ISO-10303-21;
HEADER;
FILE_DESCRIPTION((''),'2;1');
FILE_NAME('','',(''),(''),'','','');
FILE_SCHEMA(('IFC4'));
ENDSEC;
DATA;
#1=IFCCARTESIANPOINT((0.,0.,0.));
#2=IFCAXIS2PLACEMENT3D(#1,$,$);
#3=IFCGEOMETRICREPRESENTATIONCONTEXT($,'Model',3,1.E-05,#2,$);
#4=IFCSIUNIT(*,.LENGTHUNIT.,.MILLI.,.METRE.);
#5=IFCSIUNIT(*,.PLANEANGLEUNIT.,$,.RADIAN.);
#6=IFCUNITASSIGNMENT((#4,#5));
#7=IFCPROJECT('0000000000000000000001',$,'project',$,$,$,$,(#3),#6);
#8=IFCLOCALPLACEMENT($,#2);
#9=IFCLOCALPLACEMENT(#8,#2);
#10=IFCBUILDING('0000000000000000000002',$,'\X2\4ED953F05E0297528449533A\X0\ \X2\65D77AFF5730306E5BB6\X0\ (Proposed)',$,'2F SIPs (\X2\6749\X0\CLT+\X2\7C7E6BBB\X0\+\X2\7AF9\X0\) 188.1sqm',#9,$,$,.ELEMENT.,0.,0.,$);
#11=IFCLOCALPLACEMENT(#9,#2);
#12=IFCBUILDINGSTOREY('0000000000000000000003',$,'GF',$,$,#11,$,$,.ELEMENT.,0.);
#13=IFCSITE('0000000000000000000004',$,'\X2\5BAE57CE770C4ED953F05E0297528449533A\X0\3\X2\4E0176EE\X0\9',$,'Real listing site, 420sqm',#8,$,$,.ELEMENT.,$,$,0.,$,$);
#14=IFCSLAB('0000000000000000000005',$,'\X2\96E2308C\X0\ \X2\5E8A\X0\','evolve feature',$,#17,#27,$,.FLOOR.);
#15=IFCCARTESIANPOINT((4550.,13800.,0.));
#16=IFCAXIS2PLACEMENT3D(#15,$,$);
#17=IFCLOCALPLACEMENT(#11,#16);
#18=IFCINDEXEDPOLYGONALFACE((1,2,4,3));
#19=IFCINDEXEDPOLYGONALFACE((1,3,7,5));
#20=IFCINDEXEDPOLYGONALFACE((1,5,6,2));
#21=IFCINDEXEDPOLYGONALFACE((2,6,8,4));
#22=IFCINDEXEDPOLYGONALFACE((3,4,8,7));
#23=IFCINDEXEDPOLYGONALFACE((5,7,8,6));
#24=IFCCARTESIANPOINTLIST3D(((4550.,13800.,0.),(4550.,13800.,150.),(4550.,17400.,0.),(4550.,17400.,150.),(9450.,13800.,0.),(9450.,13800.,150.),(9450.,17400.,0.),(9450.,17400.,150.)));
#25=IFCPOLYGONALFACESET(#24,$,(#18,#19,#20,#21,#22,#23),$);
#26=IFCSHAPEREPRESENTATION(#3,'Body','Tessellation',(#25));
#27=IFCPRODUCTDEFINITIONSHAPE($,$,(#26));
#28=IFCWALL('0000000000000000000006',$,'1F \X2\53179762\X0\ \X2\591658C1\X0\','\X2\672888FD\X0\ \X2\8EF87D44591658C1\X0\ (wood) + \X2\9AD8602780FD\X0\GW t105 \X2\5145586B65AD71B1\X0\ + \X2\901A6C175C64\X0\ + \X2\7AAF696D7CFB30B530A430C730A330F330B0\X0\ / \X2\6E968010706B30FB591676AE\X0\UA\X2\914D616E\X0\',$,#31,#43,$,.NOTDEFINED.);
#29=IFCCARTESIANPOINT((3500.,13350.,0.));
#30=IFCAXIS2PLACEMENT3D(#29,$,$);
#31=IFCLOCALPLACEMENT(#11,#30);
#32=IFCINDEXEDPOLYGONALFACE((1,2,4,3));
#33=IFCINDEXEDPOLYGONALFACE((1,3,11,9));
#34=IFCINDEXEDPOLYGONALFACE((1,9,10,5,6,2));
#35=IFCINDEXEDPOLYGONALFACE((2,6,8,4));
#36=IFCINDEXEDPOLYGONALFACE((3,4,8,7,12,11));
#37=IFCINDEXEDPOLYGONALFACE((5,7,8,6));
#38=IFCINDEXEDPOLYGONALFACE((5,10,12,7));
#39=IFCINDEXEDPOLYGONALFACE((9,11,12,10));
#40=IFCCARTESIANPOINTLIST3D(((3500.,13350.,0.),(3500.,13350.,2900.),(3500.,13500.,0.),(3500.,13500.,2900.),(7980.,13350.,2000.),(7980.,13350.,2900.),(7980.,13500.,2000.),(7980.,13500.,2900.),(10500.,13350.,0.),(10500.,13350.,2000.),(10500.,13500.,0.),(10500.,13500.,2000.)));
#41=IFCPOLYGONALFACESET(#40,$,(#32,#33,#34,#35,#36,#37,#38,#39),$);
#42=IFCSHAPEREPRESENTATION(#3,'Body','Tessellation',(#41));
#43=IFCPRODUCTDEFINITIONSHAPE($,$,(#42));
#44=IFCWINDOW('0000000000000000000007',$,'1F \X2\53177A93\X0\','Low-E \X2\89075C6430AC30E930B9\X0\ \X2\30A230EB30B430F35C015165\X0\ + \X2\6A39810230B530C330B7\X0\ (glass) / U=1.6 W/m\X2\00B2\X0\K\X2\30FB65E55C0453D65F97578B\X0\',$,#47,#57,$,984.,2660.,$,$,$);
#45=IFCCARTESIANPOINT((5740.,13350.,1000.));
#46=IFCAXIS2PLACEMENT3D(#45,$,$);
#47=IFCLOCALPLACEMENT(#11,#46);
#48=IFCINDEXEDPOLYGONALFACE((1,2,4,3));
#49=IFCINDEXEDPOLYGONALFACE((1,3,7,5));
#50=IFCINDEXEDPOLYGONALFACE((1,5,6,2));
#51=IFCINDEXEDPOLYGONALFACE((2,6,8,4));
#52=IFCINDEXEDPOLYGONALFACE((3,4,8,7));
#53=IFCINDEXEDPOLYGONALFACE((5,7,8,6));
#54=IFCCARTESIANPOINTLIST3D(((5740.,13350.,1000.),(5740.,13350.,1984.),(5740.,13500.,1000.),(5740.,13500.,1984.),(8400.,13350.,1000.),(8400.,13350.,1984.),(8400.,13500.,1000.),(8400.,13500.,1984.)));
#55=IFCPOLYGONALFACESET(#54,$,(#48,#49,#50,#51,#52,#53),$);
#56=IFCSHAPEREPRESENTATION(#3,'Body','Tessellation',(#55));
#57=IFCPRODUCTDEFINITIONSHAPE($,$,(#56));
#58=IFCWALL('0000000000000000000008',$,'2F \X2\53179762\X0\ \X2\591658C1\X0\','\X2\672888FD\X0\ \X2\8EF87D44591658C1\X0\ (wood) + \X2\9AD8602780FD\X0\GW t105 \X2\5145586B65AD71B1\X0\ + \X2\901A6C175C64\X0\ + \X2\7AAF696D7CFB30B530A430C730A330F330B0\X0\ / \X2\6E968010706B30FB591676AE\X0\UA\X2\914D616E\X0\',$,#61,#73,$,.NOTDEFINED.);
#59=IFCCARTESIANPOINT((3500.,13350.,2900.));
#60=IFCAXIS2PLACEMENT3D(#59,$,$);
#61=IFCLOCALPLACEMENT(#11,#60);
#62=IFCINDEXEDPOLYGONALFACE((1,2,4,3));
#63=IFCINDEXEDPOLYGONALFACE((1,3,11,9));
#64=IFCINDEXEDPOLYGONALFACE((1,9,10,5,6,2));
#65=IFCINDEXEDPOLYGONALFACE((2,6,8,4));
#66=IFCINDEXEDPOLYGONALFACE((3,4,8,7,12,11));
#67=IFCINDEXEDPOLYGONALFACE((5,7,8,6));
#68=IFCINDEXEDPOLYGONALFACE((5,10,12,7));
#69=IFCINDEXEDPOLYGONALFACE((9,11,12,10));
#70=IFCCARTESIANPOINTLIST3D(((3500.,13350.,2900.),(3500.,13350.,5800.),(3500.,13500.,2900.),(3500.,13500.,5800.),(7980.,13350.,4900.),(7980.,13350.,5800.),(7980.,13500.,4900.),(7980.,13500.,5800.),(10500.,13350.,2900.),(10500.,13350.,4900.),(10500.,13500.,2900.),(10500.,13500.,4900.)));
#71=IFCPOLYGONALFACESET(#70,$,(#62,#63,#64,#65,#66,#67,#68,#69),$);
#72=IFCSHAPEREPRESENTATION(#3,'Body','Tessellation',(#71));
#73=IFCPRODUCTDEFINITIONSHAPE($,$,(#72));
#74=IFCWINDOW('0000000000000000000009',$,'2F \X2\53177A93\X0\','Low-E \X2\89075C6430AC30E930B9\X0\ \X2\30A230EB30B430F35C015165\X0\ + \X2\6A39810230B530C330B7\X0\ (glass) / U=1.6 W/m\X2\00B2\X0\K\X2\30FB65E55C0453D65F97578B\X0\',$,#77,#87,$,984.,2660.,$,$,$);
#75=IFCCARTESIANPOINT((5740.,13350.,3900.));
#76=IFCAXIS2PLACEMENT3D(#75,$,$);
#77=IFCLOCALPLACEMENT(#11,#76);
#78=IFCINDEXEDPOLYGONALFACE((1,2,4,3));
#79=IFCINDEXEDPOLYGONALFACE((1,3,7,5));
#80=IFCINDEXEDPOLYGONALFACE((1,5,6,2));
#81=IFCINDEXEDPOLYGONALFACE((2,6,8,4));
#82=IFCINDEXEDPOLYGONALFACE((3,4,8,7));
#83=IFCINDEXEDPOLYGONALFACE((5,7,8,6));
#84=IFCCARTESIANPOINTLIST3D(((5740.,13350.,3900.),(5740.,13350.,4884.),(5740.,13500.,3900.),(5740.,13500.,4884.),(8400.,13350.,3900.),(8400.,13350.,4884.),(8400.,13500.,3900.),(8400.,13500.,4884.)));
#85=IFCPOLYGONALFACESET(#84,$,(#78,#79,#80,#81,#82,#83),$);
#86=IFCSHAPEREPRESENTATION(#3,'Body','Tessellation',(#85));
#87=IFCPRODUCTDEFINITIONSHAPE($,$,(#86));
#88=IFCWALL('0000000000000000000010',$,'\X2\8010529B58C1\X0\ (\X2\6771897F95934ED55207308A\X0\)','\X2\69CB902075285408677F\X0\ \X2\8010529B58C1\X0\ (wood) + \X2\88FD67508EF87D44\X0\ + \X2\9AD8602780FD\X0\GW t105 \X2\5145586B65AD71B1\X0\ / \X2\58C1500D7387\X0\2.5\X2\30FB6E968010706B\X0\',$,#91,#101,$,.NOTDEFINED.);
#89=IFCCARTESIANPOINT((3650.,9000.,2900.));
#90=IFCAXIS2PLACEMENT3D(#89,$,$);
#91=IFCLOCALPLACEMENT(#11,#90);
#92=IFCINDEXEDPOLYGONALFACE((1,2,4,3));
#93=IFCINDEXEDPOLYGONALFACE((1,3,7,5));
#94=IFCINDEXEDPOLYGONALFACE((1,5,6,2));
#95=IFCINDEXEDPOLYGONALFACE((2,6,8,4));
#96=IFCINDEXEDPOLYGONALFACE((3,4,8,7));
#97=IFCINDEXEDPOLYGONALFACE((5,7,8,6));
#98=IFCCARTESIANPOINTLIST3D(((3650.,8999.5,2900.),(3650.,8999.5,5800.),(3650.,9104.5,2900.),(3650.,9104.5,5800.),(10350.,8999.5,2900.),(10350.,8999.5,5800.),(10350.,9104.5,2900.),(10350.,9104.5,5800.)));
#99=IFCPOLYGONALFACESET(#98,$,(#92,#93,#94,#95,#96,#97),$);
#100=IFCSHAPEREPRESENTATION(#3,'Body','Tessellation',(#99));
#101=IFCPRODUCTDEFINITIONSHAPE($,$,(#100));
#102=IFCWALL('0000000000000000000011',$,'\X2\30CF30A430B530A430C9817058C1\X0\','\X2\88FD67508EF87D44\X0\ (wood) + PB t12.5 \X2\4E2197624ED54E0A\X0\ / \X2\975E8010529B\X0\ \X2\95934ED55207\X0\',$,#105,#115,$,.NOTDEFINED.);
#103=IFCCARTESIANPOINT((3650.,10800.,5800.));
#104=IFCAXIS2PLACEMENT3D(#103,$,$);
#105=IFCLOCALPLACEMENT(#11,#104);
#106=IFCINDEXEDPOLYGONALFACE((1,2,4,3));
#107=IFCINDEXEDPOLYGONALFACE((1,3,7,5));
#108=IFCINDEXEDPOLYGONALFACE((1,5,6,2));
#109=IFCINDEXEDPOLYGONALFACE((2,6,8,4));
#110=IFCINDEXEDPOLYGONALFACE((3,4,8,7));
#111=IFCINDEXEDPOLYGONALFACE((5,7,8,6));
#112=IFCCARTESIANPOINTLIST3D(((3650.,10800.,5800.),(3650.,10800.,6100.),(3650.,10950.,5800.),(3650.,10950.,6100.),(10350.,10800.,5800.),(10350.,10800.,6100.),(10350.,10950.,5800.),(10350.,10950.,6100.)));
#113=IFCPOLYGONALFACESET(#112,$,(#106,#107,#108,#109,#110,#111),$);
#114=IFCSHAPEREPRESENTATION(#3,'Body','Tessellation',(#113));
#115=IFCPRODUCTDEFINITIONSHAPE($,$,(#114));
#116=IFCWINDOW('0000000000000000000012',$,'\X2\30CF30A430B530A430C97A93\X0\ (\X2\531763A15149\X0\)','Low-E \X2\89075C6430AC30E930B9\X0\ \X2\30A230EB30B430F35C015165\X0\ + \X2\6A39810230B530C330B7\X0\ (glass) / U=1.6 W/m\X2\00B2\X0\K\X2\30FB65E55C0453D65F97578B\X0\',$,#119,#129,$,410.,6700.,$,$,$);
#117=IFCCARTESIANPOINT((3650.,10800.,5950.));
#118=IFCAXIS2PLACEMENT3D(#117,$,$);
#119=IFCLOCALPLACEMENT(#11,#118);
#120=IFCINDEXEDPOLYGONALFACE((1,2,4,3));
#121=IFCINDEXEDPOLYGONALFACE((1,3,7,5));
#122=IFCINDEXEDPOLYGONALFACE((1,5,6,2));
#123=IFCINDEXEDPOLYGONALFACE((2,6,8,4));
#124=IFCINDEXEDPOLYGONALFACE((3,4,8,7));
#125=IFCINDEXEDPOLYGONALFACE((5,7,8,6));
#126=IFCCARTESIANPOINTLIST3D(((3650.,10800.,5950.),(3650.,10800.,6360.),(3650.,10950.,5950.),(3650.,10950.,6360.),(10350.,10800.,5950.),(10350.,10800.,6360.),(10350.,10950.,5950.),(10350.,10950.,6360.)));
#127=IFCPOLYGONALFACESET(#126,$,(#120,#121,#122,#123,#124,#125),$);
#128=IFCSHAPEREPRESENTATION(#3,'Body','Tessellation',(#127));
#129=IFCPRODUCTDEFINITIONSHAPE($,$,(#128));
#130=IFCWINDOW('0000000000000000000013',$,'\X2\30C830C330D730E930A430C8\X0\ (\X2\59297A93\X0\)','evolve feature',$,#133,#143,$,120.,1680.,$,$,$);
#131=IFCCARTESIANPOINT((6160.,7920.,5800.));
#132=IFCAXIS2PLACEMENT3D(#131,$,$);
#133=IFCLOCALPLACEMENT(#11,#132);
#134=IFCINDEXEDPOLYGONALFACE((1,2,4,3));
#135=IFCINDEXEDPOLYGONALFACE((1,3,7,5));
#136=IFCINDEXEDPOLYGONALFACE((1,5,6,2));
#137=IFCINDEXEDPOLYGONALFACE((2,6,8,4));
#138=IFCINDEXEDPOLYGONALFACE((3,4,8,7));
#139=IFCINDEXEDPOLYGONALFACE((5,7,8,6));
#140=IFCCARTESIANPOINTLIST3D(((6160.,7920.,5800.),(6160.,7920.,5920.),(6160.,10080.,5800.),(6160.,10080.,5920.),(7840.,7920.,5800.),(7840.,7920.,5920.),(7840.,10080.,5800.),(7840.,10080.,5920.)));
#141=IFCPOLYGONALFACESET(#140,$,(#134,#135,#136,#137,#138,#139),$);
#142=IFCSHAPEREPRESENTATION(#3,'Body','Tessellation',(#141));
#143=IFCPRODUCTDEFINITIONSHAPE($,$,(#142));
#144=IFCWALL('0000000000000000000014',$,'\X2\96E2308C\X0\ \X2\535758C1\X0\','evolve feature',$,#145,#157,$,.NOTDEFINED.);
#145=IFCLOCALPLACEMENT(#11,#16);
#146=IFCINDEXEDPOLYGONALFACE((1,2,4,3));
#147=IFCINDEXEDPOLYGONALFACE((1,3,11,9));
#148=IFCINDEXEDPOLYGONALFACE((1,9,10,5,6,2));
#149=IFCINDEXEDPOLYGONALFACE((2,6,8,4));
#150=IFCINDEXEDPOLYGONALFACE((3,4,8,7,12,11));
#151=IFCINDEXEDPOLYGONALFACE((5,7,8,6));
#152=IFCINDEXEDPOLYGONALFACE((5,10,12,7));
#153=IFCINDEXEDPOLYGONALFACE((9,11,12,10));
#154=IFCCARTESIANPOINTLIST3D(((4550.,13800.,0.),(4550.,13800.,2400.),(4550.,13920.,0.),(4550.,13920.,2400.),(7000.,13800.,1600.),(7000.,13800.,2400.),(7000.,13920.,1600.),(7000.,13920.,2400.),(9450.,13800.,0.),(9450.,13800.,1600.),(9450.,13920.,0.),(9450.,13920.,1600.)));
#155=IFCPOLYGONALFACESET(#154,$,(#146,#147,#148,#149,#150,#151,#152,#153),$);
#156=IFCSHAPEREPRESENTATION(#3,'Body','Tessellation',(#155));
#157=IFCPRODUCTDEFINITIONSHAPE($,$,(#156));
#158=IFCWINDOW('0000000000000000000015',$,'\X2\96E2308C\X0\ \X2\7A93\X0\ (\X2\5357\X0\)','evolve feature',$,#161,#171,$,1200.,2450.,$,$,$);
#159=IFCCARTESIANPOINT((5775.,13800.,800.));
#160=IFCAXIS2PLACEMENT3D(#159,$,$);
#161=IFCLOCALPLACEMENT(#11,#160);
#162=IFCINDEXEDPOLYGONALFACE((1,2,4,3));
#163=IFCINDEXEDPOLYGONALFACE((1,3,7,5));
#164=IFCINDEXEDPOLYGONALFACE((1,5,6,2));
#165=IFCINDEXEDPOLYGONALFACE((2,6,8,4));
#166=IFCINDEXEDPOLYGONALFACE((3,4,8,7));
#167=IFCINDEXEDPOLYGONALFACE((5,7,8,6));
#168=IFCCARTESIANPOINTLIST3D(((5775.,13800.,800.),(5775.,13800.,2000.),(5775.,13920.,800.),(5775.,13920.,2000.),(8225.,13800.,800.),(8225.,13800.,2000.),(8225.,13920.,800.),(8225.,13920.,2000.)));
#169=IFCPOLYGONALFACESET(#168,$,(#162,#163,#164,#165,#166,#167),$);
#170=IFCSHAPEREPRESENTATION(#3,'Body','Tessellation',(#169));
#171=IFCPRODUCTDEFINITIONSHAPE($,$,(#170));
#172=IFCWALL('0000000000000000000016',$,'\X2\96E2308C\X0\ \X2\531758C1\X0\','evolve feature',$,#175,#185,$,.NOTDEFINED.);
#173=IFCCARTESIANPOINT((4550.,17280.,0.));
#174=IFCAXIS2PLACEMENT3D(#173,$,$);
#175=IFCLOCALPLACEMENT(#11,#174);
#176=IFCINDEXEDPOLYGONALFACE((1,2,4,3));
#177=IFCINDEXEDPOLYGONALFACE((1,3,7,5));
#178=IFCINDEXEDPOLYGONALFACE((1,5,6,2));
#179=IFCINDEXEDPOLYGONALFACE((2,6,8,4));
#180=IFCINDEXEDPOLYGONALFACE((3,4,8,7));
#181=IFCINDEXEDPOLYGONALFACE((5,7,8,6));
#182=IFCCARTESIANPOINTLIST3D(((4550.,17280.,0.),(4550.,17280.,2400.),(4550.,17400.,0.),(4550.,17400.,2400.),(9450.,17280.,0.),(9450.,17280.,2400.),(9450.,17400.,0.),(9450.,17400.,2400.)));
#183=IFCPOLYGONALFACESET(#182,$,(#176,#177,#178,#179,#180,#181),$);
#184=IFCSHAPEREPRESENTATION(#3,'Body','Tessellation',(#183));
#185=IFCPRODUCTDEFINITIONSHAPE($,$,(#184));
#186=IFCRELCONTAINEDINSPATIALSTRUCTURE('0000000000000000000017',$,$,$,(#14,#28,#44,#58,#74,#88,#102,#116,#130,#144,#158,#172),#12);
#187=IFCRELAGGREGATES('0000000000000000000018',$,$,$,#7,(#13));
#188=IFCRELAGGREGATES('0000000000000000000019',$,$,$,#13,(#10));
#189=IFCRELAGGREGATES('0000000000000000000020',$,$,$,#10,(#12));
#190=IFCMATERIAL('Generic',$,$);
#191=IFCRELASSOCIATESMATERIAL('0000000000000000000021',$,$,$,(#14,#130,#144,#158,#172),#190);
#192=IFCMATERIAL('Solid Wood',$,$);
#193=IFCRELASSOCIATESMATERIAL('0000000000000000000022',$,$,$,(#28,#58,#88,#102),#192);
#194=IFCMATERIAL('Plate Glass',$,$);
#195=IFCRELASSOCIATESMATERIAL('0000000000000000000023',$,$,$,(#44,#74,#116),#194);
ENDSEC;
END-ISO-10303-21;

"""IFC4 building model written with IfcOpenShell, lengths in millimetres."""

from ifc_helpers import new_model, si_unit, frame, frame_2d, origin, place, context, project, spatial, rectangle, extrude, material, element, fill, save


model = new_model("IFC4")

# Units and contexts
model_context = context("Model", 3, precision=1e-05, world=origin())
ifc_project = project(units=[si_unit("LENGTHUNIT", "METRE", prefix="MILLI"), si_unit("PLANEANGLEUNIT", "RADIAN")], contexts=[model_context])

# Site, building, storey
site_placement = place(None, origin())
site = spatial("IfcSite", under=ifc_project, at=site_placement, Name="宮城県仙台市青葉区3丁目9", ObjectType="Real listing site, 420sqm", CompositionType="ELEMENT", RefElevation=0.0)
building_placement = place(site_placement, origin())
building = spatial("IfcBuilding", under=site, at=building_placement, Name="仙台市青葉区 旗竿地の家 (Proposed)", ObjectType="2F SIPs (杉CLT+籾殻+竹) 188.1sqm", CompositionType="ELEMENT", ElevationOfRefHeight=0.0, ElevationOfTerrain=0.0)
storey_placement = place(building_placement, origin())
storey = spatial("IfcBuildingStorey", under=building, at=storey_placement, Name="GF", CompositionType="ELEMENT", Elevation=0.0)

# Slab
ifc_material_1 = material(Name="Generic")
slab_placement = place(storey_placement, frame((4550.0, 13800.0, 0.0)))
element("IfcSlab", 1, at=slab_placement, inside=storey, material=ifc_material_1, Name="離れ 床", Description="evolve feature", PredefinedType="FLOOR", context=model_context, shape_type="SweptSolid", body=[
    extrude(rectangle(XDim=4900.0, YDim=3600.0, at=frame_2d((2450.0, 1800.0))), frame((4550.0, 13800.0, 0.0)), (0.0, 0.0, 1.0), 150.0),
])

# Wall, opening, window
ifc_material_2 = material(Name="Solid Wood")
wall_1_placement = place(storey_placement, frame((3500.0, 13350.0, 0.0)))
wall_1 = element("IfcWall", 2, at=wall_1_placement, inside=storey, material=ifc_material_2, Name="1F 北面 外壁", Description="木製 軸組外壁 (wood) + 高性能GW t105 充填断熱 + 通気層 + 窯業系サイディング / 準耐火・外皮UA配慮", PredefinedType="NOTDEFINED", context=model_context, shape_type="SweptSolid", body=[
    extrude(rectangle(XDim=7000.0, YDim=150.0, at=frame_2d((3500.0, 75.0))), frame((3500.0, 13350.0, 0.0)), (0.0, 0.0, 1.0), 2900.0),
])
opening_1_placement = place(storey_placement, frame((5740.0, 13350.0, 1000.0)))
opening_1 = element("IfcOpeningElement", 3, at=opening_1_placement, cuts=wall_1, PredefinedType="NOTDEFINED", context=model_context, shape_type="SweptSolid", body=[
    extrude(rectangle(XDim=2660.0, YDim=150.0, at=frame_2d((1330.0, 75.0))), frame((5740.0, 13350.0, 1000.0)), (0.0, 0.0, 1.0), 984.0),
])
ifc_material_3 = material(Name="Plate Glass")
window_1_placement = place(storey_placement, frame((5740.0, 13350.0, 1000.0)))
window_1 = element("IfcWindow", 4, at=window_1_placement, inside=storey, material=ifc_material_3, Name="1F 北窓", Description="Low-E 複層ガラス アルゴン封入 + 樹脂サッシ (glass) / U=1.6 W/m²K・日射取得型", OverallHeight=984.0, OverallWidth=2660.0, context=model_context, shape_type="SweptSolid", body=[
    extrude(rectangle(XDim=2660.0, YDim=150.0, at=frame_2d((1330.0, 75.0))), frame((5740.0, 13350.0, 1000.0)), (0.0, 0.0, 1.0), 984.0),
])
fill(opening_1, window_1)

# Wall, opening, window
wall_2_placement = place(storey_placement, frame((3500.0, 13350.0, 2900.0)))
wall_2 = element("IfcWall", 5, at=wall_2_placement, inside=storey, material=ifc_material_2, Name="2F 北面 外壁", Description="木製 軸組外壁 (wood) + 高性能GW t105 充填断熱 + 通気層 + 窯業系サイディング / 準耐火・外皮UA配慮", PredefinedType="NOTDEFINED", context=model_context, shape_type="SweptSolid", body=[
    extrude(rectangle(XDim=7000.0, YDim=150.0, at=frame_2d((3500.0, 75.0))), frame((3500.0, 13350.0, 2900.0)), (0.0, 0.0, 1.0), 2900.0),
])
opening_2_placement = place(storey_placement, frame((5740.0, 13350.0, 3900.0)))
opening_2 = element("IfcOpeningElement", 6, at=opening_2_placement, cuts=wall_2, PredefinedType="NOTDEFINED", context=model_context, shape_type="SweptSolid", body=[
    extrude(rectangle(XDim=2660.0, YDim=150.0, at=frame_2d((1330.0, 75.0))), frame((5740.0, 13350.0, 3900.0)), (0.0, 0.0, 1.0), 984.0),
])
window_2_placement = place(storey_placement, frame((5740.0, 13350.0, 3900.0)))
window_2 = element("IfcWindow", 7, at=window_2_placement, inside=storey, material=ifc_material_3, Name="2F 北窓", Description="Low-E 複層ガラス アルゴン封入 + 樹脂サッシ (glass) / U=1.6 W/m²K・日射取得型", OverallHeight=984.0, OverallWidth=2660.0, context=model_context, shape_type="SweptSolid", body=[
    extrude(rectangle(XDim=2660.0, YDim=150.0, at=frame_2d((1330.0, 75.0))), frame((5740.0, 13350.0, 3900.0)), (0.0, 0.0, 1.0), 984.0),
])
fill(opening_2, window_2)

# Wall
wall_3_placement = place(storey_placement, frame((3650.0, 9000.0, 2900.0)))
element("IfcWall", 8, at=wall_3_placement, inside=storey, material=ifc_material_2, Name="耐力壁 (東西間仕切り)", Description="構造用合板 耐力壁 (wood) + 製材軸組 + 高性能GW t105 充填断熱 / 壁倍率2.5・準耐火", PredefinedType="NOTDEFINED", context=model_context, shape_type="SweptSolid", body=[
    extrude(rectangle(XDim=6700.0, YDim=105.0, at=frame_2d((3350.0, 52.0))), frame((3650.0, 9000.0, 2900.0)), (0.0, 0.0, 1.0), 2900.0),
])

# Wall, opening, window
wall_4_placement = place(storey_placement, frame((3650.0, 10800.0, 5800.0)))
wall_4 = element("IfcWall", 9, at=wall_4_placement, inside=storey, material=ifc_material_2, Name="ハイサイド腰壁", Description="製材軸組 (wood) + PB t12.5 両面仕上 / 非耐力 間仕切", PredefinedType="NOTDEFINED", context=model_context, shape_type="SweptSolid", body=[
    extrude(rectangle(XDim=6700.0, YDim=150.0, at=frame_2d((3350.0, 75.0))), frame((3650.0, 10800.0, 5800.0)), (0.0, 0.0, 1.0), 700.0),
])
opening_3_placement = place(storey_placement, frame((3650.0, 10800.0, 5950.0)))
opening_3 = element("IfcOpeningElement", 10, at=opening_3_placement, cuts=wall_4, PredefinedType="NOTDEFINED", context=model_context, shape_type="SweptSolid", body=[
    extrude(rectangle(XDim=6700.0, YDim=150.0, at=frame_2d((3350.0, 75.0))), frame((3650.0, 10800.0, 5950.0)), (0.0, 0.0, 1.0), 410.0),
])
window_3_placement = place(storey_placement, frame((3650.0, 10800.0, 5950.0)))
window_3 = element("IfcWindow", 11, at=window_3_placement, inside=storey, material=ifc_material_3, Name="ハイサイド窓 (北採光)", Description="Low-E 複層ガラス アルゴン封入 + 樹脂サッシ (glass) / U=1.6 W/m²K・日射取得型", OverallHeight=410.0, OverallWidth=6700.0, context=model_context, shape_type="SweptSolid", body=[
    extrude(rectangle(XDim=6700.0, YDim=150.0, at=frame_2d((3350.0, 75.0))), frame((3650.0, 10800.0, 5950.0)), (0.0, 0.0, 1.0), 410.0),
])
fill(opening_3, window_3)

# Window
window_4_placement = place(storey_placement, frame((6160.0, 7920.0, 5800.0)))
element("IfcWindow", 12, at=window_4_placement, inside=storey, material=ifc_material_1, Name="トップライト (天窓)", Description="evolve feature", OverallHeight=120.0, OverallWidth=1680.0, context=model_context, shape_type="SweptSolid", body=[
    extrude(rectangle(XDim=1680.0, YDim=2160.0, at=frame_2d((840.0, 1080.0))), frame((6160.0, 7920.0, 5800.0)), (0.0, 0.0, 1.0), 120.0),
])

# Wall, opening, window
wall_5_placement = place(storey_placement, frame((4550.0, 13800.0, 0.0)))
wall_5 = element("IfcWall", 13, at=wall_5_placement, inside=storey, material=ifc_material_1, Name="離れ 南壁", Description="evolve feature", PredefinedType="NOTDEFINED", context=model_context, shape_type="SweptSolid", body=[
    extrude(rectangle(XDim=4900.0, YDim=120.0, at=frame_2d((2450.0, 60.0))), frame((4550.0, 13800.0, 0.0)), (0.0, 0.0, 1.0), 2400.0),
])
opening_4_placement = place(storey_placement, frame((5775.0, 13800.0, 800.0)))
opening_4 = element("IfcOpeningElement", 14, at=opening_4_placement, cuts=wall_5, PredefinedType="NOTDEFINED", context=model_context, shape_type="SweptSolid", body=[
    extrude(rectangle(XDim=2450.0, YDim=120.0, at=frame_2d((1225.0, 60.0))), frame((5775.0, 13800.0, 800.0)), (0.0, 0.0, 1.0), 1200.0),
])
window_5_placement = place(storey_placement, frame((5775.0, 13800.0, 800.0)))
window_5 = element("IfcWindow", 15, at=window_5_placement, inside=storey, material=ifc_material_1, Name="離れ 窓 (南)", Description="evolve feature", OverallHeight=1200.0, OverallWidth=2450.0, context=model_context, shape_type="SweptSolid", body=[
    extrude(rectangle(XDim=2450.0, YDim=120.0, at=frame_2d((1225.0, 60.0))), frame((5775.0, 13800.0, 800.0)), (0.0, 0.0, 1.0), 1200.0),
])
fill(opening_4, window_5)

# Wall
wall_6_placement = place(storey_placement, frame((4550.0, 17280.0, 0.0)))
element("IfcWall", 16, at=wall_6_placement, inside=storey, material=ifc_material_1, Name="離れ 北壁", Description="evolve feature", PredefinedType="NOTDEFINED", context=model_context, shape_type="SweptSolid", body=[
    extrude(rectangle(XDim=4900.0, YDim=120.0, at=frame_2d((2450.0, 60.0))), frame((4550.0, 17280.0, 0.0)), (0.0, 0.0, 1.0), 2400.0),
])

save(model, "model.ifc")
